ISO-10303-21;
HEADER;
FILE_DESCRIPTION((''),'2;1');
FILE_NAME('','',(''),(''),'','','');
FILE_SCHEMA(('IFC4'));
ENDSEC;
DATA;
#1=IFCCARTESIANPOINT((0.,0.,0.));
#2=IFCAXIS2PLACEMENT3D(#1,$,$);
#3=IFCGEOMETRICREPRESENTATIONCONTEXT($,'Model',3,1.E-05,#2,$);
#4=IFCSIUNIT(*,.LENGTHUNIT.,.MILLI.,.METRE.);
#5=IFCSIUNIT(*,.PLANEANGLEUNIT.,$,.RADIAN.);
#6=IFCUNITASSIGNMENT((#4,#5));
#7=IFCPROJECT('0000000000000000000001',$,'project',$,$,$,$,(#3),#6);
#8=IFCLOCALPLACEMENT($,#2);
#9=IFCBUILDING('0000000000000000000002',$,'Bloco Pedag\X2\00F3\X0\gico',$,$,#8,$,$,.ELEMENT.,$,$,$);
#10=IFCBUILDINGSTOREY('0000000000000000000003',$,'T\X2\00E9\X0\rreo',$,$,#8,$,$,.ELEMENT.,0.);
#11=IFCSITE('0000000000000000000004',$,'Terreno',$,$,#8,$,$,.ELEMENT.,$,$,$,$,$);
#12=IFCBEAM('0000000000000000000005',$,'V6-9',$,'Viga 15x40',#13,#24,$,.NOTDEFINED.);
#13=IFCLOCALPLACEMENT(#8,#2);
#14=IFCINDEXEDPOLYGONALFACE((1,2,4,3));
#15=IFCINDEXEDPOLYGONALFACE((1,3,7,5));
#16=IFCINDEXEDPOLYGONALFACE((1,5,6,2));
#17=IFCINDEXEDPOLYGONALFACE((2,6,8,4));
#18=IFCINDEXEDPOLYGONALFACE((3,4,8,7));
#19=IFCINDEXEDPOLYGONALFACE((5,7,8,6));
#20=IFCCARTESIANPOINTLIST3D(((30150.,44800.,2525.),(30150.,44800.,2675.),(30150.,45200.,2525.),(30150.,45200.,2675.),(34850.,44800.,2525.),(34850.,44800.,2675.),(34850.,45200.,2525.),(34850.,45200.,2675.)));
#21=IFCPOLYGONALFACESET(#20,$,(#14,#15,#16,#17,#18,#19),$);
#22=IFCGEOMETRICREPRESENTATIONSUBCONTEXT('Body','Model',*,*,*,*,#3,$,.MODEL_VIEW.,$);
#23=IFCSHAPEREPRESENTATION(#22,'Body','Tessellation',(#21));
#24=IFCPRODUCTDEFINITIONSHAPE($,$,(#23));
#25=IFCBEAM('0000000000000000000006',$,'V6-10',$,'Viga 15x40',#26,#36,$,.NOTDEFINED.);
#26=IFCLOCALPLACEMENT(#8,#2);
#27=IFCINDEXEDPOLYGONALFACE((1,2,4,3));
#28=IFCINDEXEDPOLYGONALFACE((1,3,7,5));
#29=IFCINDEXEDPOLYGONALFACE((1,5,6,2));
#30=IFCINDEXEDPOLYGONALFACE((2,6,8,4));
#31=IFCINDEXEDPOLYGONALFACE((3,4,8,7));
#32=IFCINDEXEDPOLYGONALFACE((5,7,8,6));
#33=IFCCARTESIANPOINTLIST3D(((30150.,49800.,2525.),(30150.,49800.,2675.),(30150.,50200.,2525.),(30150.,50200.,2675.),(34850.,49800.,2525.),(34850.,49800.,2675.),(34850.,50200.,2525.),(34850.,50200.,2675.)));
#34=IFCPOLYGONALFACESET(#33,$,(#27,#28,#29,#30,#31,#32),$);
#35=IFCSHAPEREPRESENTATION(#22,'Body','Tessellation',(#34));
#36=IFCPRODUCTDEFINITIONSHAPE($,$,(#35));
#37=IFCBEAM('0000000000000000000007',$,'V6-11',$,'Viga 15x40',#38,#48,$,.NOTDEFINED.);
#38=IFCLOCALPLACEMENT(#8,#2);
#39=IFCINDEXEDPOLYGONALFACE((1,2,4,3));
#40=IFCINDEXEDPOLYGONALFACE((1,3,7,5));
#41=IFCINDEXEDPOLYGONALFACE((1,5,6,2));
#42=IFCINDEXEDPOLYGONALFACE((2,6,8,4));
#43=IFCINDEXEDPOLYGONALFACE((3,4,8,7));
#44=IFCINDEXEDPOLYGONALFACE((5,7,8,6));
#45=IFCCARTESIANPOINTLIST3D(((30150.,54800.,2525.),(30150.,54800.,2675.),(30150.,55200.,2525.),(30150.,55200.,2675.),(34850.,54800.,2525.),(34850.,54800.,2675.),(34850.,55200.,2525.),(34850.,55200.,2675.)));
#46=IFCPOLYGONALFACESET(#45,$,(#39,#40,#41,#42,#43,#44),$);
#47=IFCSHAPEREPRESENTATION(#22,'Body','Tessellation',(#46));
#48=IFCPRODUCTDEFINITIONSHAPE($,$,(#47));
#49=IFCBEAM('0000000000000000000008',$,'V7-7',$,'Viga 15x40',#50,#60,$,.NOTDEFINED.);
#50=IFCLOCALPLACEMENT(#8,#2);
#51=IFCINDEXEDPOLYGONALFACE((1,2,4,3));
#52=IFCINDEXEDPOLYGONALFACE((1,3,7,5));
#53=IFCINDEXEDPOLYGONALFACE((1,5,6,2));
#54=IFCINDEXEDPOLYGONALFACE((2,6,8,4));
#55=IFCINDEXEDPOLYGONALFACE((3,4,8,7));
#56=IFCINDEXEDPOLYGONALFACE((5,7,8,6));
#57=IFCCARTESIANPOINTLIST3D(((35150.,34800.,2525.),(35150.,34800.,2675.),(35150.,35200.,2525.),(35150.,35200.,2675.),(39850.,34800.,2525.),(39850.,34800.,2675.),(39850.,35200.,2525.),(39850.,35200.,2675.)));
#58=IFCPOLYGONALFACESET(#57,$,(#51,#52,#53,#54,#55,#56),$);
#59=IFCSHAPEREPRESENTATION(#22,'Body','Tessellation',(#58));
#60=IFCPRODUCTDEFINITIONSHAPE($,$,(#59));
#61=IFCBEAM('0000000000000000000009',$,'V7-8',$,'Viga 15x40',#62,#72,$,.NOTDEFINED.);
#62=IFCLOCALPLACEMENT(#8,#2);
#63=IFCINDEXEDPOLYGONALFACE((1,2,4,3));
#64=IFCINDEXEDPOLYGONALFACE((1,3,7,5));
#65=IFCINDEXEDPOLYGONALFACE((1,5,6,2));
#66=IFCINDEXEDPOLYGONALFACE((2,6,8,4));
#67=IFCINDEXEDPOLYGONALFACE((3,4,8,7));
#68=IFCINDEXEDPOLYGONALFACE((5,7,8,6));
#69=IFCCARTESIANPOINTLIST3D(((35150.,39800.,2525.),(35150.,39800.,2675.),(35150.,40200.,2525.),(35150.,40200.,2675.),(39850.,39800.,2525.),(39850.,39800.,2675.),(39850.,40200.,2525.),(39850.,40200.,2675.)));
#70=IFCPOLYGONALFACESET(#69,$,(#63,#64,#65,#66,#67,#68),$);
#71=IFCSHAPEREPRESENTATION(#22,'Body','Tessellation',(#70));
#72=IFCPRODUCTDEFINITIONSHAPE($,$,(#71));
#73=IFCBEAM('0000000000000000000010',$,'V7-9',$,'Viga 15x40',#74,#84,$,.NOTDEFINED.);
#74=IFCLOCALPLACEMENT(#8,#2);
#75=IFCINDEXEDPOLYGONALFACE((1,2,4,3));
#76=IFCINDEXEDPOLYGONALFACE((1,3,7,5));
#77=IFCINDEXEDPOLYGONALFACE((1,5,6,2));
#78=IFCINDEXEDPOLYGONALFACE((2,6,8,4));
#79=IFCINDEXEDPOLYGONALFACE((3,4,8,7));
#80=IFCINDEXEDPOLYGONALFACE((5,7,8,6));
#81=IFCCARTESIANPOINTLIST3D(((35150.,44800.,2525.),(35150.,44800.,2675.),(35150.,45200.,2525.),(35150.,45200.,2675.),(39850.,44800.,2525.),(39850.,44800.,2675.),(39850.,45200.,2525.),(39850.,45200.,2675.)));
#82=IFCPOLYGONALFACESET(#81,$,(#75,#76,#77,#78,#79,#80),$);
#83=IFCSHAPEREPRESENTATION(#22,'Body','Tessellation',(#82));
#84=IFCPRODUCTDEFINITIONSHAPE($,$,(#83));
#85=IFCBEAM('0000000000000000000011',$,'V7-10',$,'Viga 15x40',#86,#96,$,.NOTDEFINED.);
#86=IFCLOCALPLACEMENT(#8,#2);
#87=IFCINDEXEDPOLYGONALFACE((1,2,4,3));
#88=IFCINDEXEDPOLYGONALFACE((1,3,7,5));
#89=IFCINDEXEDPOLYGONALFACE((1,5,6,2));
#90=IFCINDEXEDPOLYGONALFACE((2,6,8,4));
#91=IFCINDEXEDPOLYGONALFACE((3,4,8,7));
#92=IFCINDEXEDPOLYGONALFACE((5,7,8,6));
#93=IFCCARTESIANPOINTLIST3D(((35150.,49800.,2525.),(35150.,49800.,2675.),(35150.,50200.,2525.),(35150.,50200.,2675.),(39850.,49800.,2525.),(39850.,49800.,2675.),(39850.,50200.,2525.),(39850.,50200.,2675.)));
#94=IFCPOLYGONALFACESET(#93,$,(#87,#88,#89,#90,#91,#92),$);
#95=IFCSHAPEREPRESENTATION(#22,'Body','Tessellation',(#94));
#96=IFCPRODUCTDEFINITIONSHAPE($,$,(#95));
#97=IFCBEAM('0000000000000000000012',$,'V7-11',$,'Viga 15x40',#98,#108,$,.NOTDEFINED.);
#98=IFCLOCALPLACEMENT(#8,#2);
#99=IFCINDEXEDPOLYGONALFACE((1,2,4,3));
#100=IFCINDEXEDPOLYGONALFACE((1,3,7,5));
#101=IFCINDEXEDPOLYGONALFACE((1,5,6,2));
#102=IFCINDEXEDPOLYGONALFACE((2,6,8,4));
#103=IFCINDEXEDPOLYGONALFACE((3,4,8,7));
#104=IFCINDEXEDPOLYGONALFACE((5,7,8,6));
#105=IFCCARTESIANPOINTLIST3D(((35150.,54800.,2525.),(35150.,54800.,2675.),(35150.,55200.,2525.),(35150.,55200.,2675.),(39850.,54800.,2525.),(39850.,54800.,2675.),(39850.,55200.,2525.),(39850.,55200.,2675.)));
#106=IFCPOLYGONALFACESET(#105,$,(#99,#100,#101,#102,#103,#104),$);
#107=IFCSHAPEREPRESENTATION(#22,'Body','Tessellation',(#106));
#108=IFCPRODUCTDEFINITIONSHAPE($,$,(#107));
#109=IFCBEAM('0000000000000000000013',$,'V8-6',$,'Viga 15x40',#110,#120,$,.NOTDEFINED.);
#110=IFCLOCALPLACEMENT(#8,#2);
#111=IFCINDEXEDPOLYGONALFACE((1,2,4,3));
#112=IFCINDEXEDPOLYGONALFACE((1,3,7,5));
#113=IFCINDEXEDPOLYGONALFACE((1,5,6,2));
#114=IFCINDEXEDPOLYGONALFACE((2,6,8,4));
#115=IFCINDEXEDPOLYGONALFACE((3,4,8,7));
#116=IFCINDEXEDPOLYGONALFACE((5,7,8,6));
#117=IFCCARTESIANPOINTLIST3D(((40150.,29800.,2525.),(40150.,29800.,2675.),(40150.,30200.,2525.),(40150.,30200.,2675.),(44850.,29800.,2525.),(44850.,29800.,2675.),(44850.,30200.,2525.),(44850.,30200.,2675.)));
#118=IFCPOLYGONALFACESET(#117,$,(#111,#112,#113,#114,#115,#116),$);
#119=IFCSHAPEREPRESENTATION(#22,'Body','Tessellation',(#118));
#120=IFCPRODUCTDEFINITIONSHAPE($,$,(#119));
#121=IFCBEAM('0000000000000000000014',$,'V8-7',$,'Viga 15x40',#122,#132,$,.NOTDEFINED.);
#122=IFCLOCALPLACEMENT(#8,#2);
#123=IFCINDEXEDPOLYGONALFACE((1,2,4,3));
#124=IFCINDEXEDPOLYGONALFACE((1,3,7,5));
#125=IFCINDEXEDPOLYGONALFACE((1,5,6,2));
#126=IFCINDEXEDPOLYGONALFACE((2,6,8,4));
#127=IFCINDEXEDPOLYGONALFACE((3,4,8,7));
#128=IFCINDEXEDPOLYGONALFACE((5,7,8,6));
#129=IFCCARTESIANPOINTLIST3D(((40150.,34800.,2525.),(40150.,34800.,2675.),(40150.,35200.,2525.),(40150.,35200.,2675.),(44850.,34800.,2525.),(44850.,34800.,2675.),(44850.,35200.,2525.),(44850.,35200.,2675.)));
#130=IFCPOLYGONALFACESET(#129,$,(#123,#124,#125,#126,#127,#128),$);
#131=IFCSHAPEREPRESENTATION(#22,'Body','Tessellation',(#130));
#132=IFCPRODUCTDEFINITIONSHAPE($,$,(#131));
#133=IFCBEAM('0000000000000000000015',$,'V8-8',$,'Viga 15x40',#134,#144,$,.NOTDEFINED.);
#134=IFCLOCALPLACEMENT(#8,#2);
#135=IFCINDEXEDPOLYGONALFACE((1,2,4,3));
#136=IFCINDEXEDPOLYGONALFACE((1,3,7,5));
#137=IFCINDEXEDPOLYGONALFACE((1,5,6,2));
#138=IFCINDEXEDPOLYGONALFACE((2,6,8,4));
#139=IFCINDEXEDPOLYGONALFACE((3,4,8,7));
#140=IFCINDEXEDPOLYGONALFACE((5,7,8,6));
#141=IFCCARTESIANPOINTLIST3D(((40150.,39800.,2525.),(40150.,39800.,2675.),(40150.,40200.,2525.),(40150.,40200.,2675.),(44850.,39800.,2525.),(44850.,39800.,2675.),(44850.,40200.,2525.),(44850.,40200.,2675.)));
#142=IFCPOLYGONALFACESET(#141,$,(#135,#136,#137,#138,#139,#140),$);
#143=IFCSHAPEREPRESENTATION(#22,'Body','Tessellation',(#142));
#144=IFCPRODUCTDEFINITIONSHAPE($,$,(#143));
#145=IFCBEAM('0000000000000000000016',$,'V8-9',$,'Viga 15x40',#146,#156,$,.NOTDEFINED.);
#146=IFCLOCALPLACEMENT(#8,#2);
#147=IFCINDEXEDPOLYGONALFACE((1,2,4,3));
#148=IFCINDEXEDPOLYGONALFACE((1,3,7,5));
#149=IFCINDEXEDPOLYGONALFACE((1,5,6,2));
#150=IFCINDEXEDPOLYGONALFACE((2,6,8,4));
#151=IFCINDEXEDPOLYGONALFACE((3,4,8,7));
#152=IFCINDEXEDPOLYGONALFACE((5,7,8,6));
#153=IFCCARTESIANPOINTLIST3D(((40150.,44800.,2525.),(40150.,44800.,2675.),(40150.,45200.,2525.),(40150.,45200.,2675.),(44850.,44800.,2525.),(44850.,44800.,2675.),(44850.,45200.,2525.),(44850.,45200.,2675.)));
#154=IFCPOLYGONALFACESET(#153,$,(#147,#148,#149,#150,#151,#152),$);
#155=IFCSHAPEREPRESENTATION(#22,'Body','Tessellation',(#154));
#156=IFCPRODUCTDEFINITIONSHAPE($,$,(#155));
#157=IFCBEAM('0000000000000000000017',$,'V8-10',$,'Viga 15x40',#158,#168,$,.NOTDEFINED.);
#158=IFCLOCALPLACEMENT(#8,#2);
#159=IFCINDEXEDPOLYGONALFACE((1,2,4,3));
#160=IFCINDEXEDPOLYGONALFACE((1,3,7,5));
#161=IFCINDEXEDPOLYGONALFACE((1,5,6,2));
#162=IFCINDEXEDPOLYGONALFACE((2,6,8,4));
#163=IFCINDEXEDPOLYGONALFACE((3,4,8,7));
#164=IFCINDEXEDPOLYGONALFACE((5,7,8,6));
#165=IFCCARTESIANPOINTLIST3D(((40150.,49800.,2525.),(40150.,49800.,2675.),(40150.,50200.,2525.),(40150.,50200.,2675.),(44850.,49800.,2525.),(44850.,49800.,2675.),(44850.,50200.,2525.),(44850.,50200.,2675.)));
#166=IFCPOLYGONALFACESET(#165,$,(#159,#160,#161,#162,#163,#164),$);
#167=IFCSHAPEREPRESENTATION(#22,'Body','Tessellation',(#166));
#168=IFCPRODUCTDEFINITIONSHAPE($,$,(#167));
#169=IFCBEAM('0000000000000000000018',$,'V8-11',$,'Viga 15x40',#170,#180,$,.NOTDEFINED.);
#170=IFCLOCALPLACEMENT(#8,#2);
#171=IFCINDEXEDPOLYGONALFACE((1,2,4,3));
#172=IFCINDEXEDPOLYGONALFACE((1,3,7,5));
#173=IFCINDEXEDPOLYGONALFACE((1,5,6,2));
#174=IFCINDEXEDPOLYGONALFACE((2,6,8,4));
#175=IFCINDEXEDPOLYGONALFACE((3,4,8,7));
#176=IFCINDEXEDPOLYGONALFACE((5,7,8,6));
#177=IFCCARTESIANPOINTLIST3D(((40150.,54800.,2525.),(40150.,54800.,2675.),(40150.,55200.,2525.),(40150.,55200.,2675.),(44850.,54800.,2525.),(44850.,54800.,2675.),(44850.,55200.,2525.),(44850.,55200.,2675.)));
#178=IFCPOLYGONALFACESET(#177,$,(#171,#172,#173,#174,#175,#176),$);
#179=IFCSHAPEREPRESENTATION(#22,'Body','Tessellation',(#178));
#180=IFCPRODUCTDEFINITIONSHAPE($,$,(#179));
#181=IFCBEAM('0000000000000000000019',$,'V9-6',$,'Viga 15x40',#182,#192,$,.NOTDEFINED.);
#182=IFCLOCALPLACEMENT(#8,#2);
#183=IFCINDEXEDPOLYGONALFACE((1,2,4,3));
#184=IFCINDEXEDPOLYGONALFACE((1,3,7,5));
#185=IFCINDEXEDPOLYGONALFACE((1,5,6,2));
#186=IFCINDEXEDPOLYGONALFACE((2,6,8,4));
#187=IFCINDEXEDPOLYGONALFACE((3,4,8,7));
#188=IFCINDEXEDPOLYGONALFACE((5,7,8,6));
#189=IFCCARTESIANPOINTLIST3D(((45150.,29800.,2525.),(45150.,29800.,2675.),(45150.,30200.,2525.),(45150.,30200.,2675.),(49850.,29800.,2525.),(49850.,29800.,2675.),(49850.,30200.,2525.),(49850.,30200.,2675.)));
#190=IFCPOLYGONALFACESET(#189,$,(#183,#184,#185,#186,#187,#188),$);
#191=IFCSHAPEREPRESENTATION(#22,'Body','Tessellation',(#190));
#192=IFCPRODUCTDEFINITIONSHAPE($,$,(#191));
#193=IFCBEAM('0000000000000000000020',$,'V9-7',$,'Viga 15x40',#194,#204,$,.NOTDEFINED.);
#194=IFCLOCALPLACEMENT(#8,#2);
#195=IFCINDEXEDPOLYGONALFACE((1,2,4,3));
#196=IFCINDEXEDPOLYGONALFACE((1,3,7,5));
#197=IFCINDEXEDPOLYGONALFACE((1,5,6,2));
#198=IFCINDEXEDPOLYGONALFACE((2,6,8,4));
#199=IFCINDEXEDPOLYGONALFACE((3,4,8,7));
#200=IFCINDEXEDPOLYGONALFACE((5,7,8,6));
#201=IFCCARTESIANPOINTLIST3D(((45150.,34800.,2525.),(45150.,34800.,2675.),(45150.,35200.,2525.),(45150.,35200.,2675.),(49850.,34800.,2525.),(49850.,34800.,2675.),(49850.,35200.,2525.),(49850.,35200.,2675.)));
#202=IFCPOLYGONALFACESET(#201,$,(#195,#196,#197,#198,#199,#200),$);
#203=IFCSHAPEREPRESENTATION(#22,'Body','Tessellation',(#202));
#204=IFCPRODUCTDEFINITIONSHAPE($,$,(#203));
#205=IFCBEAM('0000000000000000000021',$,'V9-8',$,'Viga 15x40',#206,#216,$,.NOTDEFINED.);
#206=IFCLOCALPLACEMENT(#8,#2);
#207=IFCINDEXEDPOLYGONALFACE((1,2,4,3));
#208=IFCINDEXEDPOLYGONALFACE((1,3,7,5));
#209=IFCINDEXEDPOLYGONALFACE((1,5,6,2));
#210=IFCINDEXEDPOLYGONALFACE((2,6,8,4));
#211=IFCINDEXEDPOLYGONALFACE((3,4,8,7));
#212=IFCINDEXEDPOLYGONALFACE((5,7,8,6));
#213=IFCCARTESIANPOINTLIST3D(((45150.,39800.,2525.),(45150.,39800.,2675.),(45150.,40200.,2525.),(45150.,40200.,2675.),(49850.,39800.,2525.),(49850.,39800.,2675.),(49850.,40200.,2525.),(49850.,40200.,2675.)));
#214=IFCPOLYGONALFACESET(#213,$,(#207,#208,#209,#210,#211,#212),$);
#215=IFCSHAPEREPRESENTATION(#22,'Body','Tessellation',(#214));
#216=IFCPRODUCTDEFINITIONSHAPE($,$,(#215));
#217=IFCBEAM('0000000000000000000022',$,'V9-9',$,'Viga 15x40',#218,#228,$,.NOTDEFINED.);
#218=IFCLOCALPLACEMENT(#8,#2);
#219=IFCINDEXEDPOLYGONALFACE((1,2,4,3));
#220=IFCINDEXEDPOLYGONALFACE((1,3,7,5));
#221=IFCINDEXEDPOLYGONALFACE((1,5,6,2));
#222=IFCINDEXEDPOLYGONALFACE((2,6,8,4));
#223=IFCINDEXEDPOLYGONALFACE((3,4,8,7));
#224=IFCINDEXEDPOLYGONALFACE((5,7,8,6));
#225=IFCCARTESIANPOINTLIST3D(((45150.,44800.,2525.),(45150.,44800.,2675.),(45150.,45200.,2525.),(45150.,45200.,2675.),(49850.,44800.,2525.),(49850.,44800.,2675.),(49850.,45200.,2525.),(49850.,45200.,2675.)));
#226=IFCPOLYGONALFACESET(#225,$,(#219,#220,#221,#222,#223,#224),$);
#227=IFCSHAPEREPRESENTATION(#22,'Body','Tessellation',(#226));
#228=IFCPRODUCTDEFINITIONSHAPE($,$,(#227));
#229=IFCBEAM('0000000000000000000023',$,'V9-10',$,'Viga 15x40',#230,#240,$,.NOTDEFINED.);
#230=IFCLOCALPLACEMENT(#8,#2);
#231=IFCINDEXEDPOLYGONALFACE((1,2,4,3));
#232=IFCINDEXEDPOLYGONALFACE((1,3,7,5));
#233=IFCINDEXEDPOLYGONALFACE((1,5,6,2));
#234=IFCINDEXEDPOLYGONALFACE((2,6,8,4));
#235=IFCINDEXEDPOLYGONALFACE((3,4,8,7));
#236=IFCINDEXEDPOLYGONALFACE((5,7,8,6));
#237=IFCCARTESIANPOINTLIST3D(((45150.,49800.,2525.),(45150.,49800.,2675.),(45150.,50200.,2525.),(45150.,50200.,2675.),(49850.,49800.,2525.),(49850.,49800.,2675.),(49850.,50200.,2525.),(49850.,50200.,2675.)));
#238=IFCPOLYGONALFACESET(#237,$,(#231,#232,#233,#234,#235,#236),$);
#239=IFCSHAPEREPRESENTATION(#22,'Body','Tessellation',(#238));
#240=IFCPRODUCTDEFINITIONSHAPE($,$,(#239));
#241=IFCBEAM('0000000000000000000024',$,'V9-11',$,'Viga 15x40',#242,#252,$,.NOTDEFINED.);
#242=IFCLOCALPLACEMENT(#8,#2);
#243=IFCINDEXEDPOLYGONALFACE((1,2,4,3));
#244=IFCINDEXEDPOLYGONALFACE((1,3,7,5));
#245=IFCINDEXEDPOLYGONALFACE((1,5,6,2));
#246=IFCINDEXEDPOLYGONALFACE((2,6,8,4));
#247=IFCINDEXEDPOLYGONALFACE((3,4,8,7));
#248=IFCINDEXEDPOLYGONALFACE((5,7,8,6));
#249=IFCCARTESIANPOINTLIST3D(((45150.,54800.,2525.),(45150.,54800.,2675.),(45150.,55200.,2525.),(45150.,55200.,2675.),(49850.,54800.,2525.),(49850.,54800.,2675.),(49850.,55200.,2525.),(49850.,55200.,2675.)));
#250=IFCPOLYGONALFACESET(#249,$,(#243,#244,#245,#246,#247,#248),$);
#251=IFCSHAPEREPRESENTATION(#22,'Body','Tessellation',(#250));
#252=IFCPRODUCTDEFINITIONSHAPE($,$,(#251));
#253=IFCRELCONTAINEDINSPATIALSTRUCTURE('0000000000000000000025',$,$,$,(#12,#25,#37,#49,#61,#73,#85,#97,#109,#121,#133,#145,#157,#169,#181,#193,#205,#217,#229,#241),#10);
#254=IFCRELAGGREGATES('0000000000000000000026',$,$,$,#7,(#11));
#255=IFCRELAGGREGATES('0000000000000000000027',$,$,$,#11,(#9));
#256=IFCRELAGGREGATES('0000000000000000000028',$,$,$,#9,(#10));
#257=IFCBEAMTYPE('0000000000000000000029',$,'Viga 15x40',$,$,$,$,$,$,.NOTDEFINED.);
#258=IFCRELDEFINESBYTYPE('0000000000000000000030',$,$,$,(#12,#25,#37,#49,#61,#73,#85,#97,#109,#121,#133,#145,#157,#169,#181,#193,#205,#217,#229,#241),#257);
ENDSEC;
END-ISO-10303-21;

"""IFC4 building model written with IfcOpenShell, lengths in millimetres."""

from ifc_helpers import new_model, si_unit, frame, origin, origin_2d, place, context, subcontext, project, spatial, rectangle, extrude, type_object, element, save


model = new_model("IFC4")

# Units and contexts
model_context = context("Model", 3, precision=1e-05, world=origin())
body_context = subcontext(model_context, "Body", "Model", "MODEL_VIEW")
ifc_project = project(units=[si_unit("LENGTHUNIT", "METRE", prefix="MILLI"), si_unit("PLANEANGLEUNIT", "RADIAN")], contexts=[model_context])

# Site, building, storey
placement = place(None, origin())
site = spatial("IfcSite", under=ifc_project, at=placement, Name="Terreno", CompositionType="ELEMENT")
building = spatial("IfcBuilding", under=site, at=placement, Name="Bloco Pedagógico", CompositionType="ELEMENT")
storey = spatial("IfcBuildingStorey", under=building, at=placement, Name="Térreo", CompositionType="ELEMENT", Elevation=0.0)

# Beams
beam_type = type_object("IfcBeamType", Name="Viga 15x40", PredefinedType="NOTDEFINED")
for number, where, z_axis, x_axis, name in (
    (1, (30150.0, 45000.0, 2600.0), (1.0, 0.0, 0.0), (0.0, 1.0, 0.0), "V6-9"),
    (2, (30150.0, 50000.0, 2600.0), (1.0, 0.0, 0.0), (0.0, 1.0, 0.0), "V6-10"),
    (3, (30150.0, 55000.0, 2600.0), (1.0, 0.0, 0.0), (0.0, 1.0, 0.0), "V6-11"),
    (4, (35150.0, 35000.0, 2600.0), (1.0, 0.0, 0.0), (0.0, 1.0, 0.0), "V7-7"),
    (5, (35150.0, 40000.0, 2600.0), (1.0, 0.0, 0.0), (0.0, 1.0, 0.0), "V7-8"),
    (6, (35150.0, 45000.0, 2600.0), (1.0, 0.0, 0.0), (0.0, 1.0, 0.0), "V7-9"),
    (7, (35150.0, 50000.0, 2600.0), (1.0, 0.0, 0.0), (0.0, 1.0, 0.0), "V7-10"),
    (8, (35150.0, 55000.0, 2600.0), (1.0, 0.0, 0.0), (0.0, 1.0, 0.0), "V7-11"),
    (9, (40150.0, 30000.0, 2600.0), (1.0, 0.0, 0.0), (0.0, 1.0, 0.0), "V8-6"),
    (10, (40150.0, 35000.0, 2600.0), (1.0, 0.0, 0.0), (0.0, 1.0, 0.0), "V8-7"),
    (11, (40150.0, 40000.0, 2600.0), (1.0, 0.0, 0.0), (0.0, 1.0, 0.0), "V8-8"),
    (12, (40150.0, 45000.0, 2600.0), (1.0, 0.0, 0.0), (0.0, 1.0, 0.0), "V8-9"),
    (13, (40150.0, 50000.0, 2600.0), (1.0, 0.0, 0.0), (0.0, 1.0, 0.0), "V8-10"),
    (14, (40150.0, 55000.0, 2600.0), (1.0, 0.0, 0.0), (0.0, 1.0, 0.0), "V8-11"),
    (15, (45150.0, 30000.0, 2600.0), (1.0, 0.0, 0.0), (0.0, 1.0, 0.0), "V9-6"),
    (16, (45150.0, 35000.0, 2600.0), (1.0, 0.0, 0.0), (0.0, 1.0, 0.0), "V9-7"),
    (17, (45150.0, 40000.0, 2600.0), (1.0, 0.0, 0.0), (0.0, 1.0, 0.0), "V9-8"),
    (18, (45150.0, 45000.0, 2600.0), (1.0, 0.0, 0.0), (0.0, 1.0, 0.0), "V9-9"),
    (19, (45150.0, 50000.0, 2600.0), (1.0, 0.0, 0.0), (0.0, 1.0, 0.0), "V9-10"),
    (20, (45150.0, 55000.0, 2600.0), (1.0, 0.0, 0.0), (0.0, 1.0, 0.0), "V9-11"),
):
    element("IfcBeam", number, at=place(None, frame(where, z_axis=z_axis, x_axis=x_axis)), inside=storey, type_object=beam_type, Name=name, ObjectType="Viga 15x40", PredefinedType="NOTDEFINED", context=body_context, shape_type="SweptSolid", body=[
        extrude(rectangle(XDim=400.0, YDim=150.0, at=origin_2d()), None, (0.0, 0.0, 1.0), 4700.0),
    ])

save(model, "model.ifc")
